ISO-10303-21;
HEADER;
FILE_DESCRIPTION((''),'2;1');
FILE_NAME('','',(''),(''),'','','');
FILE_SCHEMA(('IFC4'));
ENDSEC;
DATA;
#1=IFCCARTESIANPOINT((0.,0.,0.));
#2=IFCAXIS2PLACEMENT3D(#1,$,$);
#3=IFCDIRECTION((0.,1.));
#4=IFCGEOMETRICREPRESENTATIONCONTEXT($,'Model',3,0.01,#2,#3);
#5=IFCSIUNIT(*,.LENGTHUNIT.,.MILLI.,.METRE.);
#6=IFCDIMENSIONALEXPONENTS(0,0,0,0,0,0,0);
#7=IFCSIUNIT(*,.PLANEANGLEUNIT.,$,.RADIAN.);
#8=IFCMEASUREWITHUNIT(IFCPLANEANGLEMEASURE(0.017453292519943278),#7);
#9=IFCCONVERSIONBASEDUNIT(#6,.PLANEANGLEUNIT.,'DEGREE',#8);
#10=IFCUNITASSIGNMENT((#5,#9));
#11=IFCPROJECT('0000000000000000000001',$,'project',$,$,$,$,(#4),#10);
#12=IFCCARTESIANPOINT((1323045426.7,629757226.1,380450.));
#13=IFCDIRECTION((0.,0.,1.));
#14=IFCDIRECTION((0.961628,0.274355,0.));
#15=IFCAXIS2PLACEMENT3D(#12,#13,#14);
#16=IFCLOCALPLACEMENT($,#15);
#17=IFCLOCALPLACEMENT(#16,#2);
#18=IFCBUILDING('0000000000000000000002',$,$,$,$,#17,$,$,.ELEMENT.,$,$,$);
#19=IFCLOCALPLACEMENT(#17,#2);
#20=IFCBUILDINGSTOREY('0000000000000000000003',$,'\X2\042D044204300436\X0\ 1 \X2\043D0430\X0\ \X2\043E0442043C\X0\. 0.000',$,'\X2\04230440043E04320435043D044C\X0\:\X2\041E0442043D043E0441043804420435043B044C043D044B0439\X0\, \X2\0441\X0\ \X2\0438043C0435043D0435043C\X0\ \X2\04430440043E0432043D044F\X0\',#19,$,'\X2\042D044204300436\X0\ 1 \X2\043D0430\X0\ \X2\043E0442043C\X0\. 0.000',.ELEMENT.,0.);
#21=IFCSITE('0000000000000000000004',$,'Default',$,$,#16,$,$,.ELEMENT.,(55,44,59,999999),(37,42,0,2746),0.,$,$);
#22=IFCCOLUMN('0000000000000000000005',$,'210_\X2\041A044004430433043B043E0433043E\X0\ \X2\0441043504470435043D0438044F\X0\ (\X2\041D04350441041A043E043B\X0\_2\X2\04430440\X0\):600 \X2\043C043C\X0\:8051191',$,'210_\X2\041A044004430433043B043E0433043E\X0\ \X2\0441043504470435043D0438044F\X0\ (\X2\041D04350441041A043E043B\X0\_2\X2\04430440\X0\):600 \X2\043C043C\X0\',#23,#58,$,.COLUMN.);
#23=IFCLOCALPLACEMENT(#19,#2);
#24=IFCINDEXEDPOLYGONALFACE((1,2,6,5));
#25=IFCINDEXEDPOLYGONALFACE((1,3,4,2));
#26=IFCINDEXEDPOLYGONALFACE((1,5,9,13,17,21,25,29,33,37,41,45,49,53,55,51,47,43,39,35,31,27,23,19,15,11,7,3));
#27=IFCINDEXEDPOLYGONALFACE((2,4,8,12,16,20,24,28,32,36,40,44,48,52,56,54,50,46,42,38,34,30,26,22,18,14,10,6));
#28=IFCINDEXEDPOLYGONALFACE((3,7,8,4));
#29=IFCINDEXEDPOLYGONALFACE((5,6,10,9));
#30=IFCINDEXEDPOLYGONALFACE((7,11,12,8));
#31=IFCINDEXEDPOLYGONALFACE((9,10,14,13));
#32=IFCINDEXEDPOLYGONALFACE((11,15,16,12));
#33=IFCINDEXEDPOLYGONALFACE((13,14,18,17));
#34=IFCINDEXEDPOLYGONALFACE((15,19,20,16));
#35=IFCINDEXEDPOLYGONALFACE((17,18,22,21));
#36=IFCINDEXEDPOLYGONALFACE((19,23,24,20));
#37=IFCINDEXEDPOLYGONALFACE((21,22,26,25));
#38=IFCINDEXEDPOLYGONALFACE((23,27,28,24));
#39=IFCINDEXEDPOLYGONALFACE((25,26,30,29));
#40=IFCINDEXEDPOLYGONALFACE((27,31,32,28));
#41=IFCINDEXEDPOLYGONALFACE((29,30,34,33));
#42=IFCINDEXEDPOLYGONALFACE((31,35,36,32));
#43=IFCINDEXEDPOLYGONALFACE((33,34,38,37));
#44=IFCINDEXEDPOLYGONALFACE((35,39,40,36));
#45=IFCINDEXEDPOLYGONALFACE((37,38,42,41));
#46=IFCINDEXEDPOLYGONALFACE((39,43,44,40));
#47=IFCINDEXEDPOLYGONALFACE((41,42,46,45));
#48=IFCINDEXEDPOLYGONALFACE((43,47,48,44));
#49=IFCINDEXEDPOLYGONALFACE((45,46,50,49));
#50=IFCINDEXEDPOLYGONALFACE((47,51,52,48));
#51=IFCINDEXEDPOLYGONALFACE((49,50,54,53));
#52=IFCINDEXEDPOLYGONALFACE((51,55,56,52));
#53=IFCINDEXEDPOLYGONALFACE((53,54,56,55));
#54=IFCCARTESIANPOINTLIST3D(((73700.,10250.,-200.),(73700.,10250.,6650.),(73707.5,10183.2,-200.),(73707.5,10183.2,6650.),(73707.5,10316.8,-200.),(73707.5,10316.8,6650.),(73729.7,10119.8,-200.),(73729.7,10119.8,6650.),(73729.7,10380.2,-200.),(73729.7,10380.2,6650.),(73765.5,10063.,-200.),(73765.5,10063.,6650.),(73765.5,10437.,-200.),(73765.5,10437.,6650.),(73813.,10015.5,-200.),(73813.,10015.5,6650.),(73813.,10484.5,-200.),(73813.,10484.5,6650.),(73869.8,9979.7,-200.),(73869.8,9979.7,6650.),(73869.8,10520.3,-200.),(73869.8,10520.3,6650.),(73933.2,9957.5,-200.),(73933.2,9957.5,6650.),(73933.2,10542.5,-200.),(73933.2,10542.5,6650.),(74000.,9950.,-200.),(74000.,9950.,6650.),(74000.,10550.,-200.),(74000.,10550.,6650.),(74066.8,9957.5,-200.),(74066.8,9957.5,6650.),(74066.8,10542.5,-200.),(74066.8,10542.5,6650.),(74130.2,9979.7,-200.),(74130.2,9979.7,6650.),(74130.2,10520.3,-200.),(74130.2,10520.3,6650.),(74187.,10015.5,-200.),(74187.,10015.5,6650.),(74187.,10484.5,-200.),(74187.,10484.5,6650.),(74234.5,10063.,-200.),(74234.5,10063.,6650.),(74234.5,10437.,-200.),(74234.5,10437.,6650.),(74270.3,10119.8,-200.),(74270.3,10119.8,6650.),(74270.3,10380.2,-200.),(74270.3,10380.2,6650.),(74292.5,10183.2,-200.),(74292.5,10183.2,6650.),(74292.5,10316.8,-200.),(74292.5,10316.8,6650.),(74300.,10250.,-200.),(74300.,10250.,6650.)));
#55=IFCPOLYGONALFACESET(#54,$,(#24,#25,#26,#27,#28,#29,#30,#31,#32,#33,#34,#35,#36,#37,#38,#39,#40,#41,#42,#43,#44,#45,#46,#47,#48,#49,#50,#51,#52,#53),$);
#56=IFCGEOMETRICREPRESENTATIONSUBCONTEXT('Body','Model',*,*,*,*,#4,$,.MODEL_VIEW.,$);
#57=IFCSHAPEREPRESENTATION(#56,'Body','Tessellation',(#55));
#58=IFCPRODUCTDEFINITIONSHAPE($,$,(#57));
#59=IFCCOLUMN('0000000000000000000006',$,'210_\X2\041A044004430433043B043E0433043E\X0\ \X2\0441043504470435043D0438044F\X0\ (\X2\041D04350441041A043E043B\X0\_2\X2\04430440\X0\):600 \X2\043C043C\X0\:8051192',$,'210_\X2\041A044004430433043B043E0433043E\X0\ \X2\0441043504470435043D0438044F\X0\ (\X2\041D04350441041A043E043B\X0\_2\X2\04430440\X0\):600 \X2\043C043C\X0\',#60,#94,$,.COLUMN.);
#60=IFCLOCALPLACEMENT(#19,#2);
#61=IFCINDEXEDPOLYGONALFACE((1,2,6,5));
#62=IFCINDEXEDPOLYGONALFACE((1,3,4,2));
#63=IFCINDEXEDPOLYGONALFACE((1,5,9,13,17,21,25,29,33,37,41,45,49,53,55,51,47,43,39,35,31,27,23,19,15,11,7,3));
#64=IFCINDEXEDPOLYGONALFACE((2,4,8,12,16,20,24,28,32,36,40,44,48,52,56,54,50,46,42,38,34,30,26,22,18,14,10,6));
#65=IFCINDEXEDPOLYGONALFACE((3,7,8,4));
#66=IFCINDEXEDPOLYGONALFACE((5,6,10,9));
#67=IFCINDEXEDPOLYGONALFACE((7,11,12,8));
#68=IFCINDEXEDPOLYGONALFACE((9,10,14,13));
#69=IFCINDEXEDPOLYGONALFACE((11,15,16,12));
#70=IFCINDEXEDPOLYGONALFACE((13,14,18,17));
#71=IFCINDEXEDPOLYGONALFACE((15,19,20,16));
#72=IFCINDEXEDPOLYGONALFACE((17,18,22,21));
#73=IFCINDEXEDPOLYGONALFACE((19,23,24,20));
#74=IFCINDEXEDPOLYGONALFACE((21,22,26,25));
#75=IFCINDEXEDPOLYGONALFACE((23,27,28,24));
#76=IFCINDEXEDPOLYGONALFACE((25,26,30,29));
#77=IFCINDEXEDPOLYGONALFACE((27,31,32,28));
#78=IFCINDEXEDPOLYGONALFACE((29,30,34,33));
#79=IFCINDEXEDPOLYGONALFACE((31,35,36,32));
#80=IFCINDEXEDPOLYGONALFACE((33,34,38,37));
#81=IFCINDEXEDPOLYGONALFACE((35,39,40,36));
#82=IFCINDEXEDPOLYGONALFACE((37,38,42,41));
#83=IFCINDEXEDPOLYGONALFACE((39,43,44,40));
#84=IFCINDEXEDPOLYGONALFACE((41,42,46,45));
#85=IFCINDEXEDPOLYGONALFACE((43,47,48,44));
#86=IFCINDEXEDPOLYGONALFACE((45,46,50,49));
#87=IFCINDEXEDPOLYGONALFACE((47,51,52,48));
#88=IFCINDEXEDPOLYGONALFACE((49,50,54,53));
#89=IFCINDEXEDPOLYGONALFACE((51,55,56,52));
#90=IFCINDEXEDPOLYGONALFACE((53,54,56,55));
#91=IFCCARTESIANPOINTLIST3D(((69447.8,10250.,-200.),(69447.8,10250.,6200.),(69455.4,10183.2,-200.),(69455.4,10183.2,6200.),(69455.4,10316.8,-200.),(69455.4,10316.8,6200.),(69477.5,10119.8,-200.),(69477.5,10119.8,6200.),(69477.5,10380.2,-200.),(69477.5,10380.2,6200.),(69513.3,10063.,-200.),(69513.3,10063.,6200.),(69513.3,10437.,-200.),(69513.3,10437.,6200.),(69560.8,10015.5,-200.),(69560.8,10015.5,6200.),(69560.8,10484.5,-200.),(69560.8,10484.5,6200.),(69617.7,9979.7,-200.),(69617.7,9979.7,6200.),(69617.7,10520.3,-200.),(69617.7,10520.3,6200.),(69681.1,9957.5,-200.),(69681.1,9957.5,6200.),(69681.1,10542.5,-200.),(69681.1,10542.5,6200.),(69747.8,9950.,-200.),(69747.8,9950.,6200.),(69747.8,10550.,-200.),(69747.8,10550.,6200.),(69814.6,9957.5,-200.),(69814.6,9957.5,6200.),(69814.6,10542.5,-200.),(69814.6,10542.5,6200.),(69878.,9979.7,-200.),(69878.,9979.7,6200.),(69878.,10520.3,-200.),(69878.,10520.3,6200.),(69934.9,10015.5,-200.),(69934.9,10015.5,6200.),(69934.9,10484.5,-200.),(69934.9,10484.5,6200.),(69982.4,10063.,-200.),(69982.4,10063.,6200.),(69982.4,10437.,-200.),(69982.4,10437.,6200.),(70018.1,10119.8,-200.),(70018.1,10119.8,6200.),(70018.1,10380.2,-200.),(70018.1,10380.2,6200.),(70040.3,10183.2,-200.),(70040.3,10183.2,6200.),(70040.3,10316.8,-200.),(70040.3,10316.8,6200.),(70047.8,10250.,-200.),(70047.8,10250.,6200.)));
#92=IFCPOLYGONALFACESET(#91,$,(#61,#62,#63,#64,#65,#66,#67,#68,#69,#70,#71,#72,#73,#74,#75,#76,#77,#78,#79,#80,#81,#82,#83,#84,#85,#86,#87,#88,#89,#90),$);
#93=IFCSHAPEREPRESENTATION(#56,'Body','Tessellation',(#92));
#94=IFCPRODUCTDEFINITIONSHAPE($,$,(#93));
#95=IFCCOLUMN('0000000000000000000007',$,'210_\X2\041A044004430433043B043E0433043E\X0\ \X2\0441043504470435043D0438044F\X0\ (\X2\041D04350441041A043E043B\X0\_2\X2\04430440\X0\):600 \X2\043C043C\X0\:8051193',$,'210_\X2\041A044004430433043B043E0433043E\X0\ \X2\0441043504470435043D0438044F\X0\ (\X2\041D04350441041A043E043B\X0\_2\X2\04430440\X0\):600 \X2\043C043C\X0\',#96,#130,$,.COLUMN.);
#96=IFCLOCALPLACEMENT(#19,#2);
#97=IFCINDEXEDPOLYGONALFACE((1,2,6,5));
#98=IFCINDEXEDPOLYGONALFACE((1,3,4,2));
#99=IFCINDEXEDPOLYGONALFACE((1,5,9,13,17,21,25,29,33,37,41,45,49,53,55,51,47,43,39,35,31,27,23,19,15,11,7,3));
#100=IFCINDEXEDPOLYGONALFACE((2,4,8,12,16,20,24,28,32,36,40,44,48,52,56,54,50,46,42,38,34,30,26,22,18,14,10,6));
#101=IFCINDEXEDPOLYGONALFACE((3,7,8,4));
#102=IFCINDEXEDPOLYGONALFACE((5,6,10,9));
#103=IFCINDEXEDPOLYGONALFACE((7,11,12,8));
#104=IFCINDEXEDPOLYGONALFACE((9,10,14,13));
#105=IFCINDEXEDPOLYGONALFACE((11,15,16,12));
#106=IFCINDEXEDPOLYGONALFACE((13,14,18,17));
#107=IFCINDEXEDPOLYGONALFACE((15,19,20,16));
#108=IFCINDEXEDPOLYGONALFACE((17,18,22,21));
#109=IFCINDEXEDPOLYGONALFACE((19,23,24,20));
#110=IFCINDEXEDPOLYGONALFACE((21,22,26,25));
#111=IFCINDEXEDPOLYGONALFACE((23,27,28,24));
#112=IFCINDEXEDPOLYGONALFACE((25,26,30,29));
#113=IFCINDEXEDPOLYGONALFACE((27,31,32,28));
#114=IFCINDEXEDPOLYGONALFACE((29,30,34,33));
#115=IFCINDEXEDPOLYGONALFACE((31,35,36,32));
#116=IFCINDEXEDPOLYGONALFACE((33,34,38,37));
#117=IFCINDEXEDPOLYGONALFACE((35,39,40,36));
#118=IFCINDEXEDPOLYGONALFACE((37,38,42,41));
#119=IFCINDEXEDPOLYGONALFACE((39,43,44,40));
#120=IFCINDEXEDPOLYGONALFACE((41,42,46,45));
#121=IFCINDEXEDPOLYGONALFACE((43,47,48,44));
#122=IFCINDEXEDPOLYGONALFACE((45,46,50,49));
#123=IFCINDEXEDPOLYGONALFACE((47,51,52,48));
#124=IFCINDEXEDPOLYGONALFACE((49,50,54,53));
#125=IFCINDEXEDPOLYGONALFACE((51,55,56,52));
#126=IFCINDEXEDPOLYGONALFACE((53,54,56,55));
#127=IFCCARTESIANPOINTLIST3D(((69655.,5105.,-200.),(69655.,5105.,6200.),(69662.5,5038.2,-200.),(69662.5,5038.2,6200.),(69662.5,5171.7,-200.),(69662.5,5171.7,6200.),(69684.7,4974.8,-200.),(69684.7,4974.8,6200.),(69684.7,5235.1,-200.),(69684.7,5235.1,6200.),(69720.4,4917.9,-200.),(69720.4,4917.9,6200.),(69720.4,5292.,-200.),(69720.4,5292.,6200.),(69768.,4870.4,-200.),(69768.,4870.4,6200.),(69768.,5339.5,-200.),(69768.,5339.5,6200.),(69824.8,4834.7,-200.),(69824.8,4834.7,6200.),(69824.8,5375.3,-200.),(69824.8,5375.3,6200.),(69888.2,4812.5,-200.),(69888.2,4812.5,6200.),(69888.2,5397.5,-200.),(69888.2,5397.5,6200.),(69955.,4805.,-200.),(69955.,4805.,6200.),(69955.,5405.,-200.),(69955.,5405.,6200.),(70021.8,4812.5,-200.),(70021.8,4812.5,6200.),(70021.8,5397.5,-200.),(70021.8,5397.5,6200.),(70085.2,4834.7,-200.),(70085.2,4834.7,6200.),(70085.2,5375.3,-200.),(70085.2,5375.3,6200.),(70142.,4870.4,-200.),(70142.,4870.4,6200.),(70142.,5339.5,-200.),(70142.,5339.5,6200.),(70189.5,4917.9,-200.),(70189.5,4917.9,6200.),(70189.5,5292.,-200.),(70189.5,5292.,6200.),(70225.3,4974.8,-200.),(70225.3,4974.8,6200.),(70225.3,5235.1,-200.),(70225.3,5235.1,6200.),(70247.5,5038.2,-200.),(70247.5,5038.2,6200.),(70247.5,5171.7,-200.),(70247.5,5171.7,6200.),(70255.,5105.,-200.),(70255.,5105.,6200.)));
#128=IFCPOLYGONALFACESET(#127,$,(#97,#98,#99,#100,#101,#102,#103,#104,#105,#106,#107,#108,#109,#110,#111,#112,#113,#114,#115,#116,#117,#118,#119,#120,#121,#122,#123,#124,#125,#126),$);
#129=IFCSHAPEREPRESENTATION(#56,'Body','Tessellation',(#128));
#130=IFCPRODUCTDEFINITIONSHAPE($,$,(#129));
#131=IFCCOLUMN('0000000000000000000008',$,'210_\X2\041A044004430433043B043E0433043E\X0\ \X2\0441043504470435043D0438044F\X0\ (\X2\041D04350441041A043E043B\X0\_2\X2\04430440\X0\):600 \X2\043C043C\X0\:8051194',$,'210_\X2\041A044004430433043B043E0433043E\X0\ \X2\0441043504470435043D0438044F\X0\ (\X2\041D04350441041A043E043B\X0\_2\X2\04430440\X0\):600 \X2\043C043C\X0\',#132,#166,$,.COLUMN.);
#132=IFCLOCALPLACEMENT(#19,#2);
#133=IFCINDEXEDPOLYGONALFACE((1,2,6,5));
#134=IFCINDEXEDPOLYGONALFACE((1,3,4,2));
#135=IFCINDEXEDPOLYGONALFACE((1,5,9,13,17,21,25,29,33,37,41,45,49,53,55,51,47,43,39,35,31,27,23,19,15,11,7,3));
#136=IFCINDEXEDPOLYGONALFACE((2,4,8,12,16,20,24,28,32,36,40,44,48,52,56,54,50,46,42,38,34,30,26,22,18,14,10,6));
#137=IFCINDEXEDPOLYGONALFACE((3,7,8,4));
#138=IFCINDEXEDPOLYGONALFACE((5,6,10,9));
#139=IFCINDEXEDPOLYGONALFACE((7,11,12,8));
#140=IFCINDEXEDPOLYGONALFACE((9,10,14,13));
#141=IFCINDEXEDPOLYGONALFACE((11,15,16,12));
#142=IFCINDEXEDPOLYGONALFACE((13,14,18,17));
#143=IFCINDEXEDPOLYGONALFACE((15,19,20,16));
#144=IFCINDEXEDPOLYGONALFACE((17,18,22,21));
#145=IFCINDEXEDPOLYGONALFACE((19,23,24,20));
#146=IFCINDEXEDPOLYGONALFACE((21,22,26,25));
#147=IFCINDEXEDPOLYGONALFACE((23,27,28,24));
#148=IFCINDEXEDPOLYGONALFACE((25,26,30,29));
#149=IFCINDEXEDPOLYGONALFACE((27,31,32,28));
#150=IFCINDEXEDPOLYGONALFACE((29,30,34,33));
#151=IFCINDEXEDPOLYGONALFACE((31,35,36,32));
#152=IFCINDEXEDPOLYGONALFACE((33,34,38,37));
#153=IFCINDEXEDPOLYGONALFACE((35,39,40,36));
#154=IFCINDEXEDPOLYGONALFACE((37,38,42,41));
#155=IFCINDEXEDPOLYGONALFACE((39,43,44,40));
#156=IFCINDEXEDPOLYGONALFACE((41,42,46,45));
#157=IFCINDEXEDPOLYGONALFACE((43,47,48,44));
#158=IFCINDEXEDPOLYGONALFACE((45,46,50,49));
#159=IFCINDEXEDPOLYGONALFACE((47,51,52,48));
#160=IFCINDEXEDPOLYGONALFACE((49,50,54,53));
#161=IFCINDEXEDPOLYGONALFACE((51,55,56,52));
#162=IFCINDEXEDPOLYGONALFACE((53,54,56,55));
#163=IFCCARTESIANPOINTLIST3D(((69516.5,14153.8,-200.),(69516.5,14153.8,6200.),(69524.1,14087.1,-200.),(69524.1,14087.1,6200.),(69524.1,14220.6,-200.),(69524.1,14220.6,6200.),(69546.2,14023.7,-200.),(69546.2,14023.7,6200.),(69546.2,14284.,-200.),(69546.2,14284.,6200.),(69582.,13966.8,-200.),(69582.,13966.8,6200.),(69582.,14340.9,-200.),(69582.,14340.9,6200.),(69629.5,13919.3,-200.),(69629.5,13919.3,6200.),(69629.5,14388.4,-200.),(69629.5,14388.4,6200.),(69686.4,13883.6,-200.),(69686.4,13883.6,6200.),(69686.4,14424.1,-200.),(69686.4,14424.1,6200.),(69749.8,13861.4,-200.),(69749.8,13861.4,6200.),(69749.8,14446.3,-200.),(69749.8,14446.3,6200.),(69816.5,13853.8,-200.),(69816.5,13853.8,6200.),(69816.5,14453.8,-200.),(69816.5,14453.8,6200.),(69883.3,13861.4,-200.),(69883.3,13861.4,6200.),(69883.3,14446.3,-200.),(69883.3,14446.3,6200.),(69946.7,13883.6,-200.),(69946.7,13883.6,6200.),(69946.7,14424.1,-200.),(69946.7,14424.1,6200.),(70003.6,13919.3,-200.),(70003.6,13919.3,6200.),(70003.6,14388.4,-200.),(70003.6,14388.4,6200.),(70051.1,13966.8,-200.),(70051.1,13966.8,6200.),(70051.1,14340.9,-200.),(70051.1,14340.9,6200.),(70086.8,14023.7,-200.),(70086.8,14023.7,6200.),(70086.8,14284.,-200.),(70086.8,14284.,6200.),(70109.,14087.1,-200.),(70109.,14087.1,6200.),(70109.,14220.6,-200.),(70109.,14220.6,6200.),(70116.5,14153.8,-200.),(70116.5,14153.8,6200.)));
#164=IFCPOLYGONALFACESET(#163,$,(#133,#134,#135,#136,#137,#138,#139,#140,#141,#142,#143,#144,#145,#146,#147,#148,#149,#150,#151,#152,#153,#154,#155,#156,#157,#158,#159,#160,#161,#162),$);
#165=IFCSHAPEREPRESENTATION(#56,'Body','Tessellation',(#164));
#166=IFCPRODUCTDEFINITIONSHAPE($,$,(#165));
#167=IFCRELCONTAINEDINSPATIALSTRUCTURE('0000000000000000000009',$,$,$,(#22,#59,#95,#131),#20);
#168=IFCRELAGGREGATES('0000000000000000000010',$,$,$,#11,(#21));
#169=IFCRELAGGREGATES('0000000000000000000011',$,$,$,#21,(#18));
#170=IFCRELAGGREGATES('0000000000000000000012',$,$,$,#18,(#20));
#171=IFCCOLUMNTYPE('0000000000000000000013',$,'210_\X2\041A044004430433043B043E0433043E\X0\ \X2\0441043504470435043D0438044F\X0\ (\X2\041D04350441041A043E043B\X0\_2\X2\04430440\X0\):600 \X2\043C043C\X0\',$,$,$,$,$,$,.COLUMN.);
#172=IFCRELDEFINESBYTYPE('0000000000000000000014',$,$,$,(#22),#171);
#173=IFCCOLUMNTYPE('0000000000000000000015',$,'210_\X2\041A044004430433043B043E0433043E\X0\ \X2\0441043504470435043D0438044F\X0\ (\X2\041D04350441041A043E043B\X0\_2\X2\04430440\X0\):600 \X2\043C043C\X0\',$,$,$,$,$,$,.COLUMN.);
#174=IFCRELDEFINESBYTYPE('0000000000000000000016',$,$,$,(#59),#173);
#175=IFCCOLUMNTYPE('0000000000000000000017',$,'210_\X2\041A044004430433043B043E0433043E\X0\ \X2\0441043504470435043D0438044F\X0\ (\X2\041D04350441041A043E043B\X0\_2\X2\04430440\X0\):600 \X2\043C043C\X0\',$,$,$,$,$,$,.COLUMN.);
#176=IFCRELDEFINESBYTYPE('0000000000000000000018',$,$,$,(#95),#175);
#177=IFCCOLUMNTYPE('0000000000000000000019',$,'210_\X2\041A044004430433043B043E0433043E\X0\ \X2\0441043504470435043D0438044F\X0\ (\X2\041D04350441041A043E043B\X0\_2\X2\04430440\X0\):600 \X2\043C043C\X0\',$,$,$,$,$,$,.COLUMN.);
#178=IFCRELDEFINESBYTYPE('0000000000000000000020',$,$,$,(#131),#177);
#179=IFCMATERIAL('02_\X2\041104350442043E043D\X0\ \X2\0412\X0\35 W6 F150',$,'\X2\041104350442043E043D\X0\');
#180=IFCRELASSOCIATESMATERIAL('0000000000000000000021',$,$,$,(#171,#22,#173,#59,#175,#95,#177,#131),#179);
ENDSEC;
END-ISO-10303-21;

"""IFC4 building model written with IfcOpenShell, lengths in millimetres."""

from ifc_helpers import new_model, entity, si_unit, converted_unit, direction, frame, origin, place, context, subcontext, project, spatial, arc, indexed_curve, outline, extrude, source, transform, mapped, material, type_object, type_shapes, element, save


model = new_model("IFC4")

# Units and contexts
model_context = context("Model", 3, precision=0.01, world=origin(), true_north=direction((0.0, 1.0)))
body_context = subcontext(model_context, "Body", "Model", "MODEL_VIEW")
ifc_project = project(units=[si_unit("LENGTHUNIT", "METRE", prefix="MILLI"), converted_unit("PLANEANGLEUNIT", "DEGREE", entity("IfcPlaneAngleMeasure", 0.017453292519943278), si_unit("PLANEANGLEUNIT", "RADIAN"), dimensions=[0, 0, 0, 0, 0, 0, 0])], contexts=[model_context])

# Site, building, storey
site_placement = place(None, frame((1323045426.7, 629757226.1, 380450.0), z_axis=(0.0, 0.0, 1.0), x_axis=(0.961628, 0.274355, 0.0)))
site = spatial("IfcSite", under=ifc_project, at=site_placement, Name="Default", CompositionType="ELEMENT", RefLatitude=(55, 44, 59, 999999), RefLongitude=(37, 42, 0, 2746), RefElevation=0.0)
building_placement = place(site_placement, origin())
building = spatial("IfcBuilding", under=site, at=building_placement, CompositionType="ELEMENT")
storey_placement = place(building_placement, origin())
storey = spatial("IfcBuildingStorey", under=building, at=storey_placement, Name="Этаж 1 на отм. 0.000", ObjectType="Уровень:Относительный, с именем уровня", LongName="Этаж 1 на отм. 0.000", CompositionType="ELEMENT", Elevation=0.0)

# Columns
ifc_material = material(Name="02_Бетон В35 W6 F150", Category="Бетон")
column_type_1 = type_object("IfcColumnType", Name="210_Круглого сечения (НесКол_2ур):600 мм", PredefinedType="COLUMN", material=ifc_material)
shared_shape_1 = source(origin(), body_context, "Body", "SweptSolid", [
    extrude(outline(indexed_curve([(-300.0, 0.0), (0.0, -300.0), (300.0, 0.0), (0.0, 300.0)], segments=[arc(1, 2, 3), arc(3, 4, 1)], self_intersect=False)), frame((74000.0, 10250.0, -200.0)), (0.0, 0.0, 1.0), 6850.0),
])
type_shapes(column_type_1, [shared_shape_1])
column_1_placement = place(storey_placement, origin())
element("IfcColumn", 1, at=column_1_placement, inside=storey, type_object=column_type_1, material=ifc_material, Name="210_Круглого сечения (НесКол_2ур):600 мм:8051191", ObjectType="210_Круглого сечения (НесКол_2ур):600 мм", PredefinedType="COLUMN", context=body_context, shape_type="MappedRepresentation", body=[
    mapped(shared_shape_1, transform((0.0, 0.0, 0.0), scale=1.0)),
])
column_type_2 = type_object("IfcColumnType", Name="210_Круглого сечения (НесКол_2ур):600 мм", PredefinedType="COLUMN", material=ifc_material)
shared_shape_2 = source(origin(), body_context, "Body", "SweptSolid", [
    extrude(outline(indexed_curve([(-300.0, 0.0), (0.0, -300.0), (300.0, 0.0), (0.0, 300.0)], segments=[arc(1, 2, 3), arc(3, 4, 1)], self_intersect=False)), frame((69747.8, 10250.0, -200.0)), (0.0, 0.0, 1.0), 6400.0),
])
type_shapes(column_type_2, [shared_shape_2])
column_2_placement = place(storey_placement, origin())
element("IfcColumn", 2, at=column_2_placement, inside=storey, type_object=column_type_2, material=ifc_material, Name="210_Круглого сечения (НесКол_2ур):600 мм:8051192", ObjectType="210_Круглого сечения (НесКол_2ур):600 мм", PredefinedType="COLUMN", context=body_context, shape_type="MappedRepresentation", body=[
    mapped(shared_shape_2, transform((0.0, 0.0, 0.0), scale=1.0)),
])
column_type_3 = type_object("IfcColumnType", Name="210_Круглого сечения (НесКол_2ур):600 мм", PredefinedType="COLUMN", material=ifc_material)
shared_shape_3 = source(origin(), body_context, "Body", "SweptSolid", [
    extrude(outline(indexed_curve([(-300.0, 0.0), (0.0, -300.0), (300.0, 0.0), (0.0, 300.0)], segments=[arc(1, 2, 3), arc(3, 4, 1)], self_intersect=False)), frame((69955.0, 5105.0, -200.0)), (0.0, 0.0, 1.0), 6400.0),
])
type_shapes(column_type_3, [shared_shape_3])
column_3_placement = place(storey_placement, origin())
element("IfcColumn", 3, at=column_3_placement, inside=storey, type_object=column_type_3, material=ifc_material, Name="210_Круглого сечения (НесКол_2ур):600 мм:8051193", ObjectType="210_Круглого сечения (НесКол_2ур):600 мм", PredefinedType="COLUMN", context=body_context, shape_type="MappedRepresentation", body=[
    mapped(shared_shape_3, transform((0.0, 0.0, 0.0), scale=1.0)),
])
column_type_4 = type_object("IfcColumnType", Name="210_Круглого сечения (НесКол_2ур):600 мм", PredefinedType="COLUMN", material=ifc_material)
shared_shape_4 = source(origin(), body_context, "Body", "SweptSolid", [
    extrude(outline(indexed_curve([(-300.0, 0.0), (0.0, -300.0), (300.0, 0.0), (0.0, 300.0)], segments=[arc(1, 2, 3), arc(3, 4, 1)], self_intersect=False)), frame((69816.5, 14153.8, -200.0)), (0.0, 0.0, 1.0), 6400.0),
])
type_shapes(column_type_4, [shared_shape_4])
column_4_placement = place(storey_placement, origin())
element("IfcColumn", 4, at=column_4_placement, inside=storey, type_object=column_type_4, material=ifc_material, Name="210_Круглого сечения (НесКол_2ур):600 мм:8051194", ObjectType="210_Круглого сечения (НесКол_2ур):600 мм", PredefinedType="COLUMN", context=body_context, shape_type="MappedRepresentation", body=[
    mapped(shared_shape_4, transform((0.0, 0.0, 0.0), scale=1.0)),
])

save(model, "model.ifc")
